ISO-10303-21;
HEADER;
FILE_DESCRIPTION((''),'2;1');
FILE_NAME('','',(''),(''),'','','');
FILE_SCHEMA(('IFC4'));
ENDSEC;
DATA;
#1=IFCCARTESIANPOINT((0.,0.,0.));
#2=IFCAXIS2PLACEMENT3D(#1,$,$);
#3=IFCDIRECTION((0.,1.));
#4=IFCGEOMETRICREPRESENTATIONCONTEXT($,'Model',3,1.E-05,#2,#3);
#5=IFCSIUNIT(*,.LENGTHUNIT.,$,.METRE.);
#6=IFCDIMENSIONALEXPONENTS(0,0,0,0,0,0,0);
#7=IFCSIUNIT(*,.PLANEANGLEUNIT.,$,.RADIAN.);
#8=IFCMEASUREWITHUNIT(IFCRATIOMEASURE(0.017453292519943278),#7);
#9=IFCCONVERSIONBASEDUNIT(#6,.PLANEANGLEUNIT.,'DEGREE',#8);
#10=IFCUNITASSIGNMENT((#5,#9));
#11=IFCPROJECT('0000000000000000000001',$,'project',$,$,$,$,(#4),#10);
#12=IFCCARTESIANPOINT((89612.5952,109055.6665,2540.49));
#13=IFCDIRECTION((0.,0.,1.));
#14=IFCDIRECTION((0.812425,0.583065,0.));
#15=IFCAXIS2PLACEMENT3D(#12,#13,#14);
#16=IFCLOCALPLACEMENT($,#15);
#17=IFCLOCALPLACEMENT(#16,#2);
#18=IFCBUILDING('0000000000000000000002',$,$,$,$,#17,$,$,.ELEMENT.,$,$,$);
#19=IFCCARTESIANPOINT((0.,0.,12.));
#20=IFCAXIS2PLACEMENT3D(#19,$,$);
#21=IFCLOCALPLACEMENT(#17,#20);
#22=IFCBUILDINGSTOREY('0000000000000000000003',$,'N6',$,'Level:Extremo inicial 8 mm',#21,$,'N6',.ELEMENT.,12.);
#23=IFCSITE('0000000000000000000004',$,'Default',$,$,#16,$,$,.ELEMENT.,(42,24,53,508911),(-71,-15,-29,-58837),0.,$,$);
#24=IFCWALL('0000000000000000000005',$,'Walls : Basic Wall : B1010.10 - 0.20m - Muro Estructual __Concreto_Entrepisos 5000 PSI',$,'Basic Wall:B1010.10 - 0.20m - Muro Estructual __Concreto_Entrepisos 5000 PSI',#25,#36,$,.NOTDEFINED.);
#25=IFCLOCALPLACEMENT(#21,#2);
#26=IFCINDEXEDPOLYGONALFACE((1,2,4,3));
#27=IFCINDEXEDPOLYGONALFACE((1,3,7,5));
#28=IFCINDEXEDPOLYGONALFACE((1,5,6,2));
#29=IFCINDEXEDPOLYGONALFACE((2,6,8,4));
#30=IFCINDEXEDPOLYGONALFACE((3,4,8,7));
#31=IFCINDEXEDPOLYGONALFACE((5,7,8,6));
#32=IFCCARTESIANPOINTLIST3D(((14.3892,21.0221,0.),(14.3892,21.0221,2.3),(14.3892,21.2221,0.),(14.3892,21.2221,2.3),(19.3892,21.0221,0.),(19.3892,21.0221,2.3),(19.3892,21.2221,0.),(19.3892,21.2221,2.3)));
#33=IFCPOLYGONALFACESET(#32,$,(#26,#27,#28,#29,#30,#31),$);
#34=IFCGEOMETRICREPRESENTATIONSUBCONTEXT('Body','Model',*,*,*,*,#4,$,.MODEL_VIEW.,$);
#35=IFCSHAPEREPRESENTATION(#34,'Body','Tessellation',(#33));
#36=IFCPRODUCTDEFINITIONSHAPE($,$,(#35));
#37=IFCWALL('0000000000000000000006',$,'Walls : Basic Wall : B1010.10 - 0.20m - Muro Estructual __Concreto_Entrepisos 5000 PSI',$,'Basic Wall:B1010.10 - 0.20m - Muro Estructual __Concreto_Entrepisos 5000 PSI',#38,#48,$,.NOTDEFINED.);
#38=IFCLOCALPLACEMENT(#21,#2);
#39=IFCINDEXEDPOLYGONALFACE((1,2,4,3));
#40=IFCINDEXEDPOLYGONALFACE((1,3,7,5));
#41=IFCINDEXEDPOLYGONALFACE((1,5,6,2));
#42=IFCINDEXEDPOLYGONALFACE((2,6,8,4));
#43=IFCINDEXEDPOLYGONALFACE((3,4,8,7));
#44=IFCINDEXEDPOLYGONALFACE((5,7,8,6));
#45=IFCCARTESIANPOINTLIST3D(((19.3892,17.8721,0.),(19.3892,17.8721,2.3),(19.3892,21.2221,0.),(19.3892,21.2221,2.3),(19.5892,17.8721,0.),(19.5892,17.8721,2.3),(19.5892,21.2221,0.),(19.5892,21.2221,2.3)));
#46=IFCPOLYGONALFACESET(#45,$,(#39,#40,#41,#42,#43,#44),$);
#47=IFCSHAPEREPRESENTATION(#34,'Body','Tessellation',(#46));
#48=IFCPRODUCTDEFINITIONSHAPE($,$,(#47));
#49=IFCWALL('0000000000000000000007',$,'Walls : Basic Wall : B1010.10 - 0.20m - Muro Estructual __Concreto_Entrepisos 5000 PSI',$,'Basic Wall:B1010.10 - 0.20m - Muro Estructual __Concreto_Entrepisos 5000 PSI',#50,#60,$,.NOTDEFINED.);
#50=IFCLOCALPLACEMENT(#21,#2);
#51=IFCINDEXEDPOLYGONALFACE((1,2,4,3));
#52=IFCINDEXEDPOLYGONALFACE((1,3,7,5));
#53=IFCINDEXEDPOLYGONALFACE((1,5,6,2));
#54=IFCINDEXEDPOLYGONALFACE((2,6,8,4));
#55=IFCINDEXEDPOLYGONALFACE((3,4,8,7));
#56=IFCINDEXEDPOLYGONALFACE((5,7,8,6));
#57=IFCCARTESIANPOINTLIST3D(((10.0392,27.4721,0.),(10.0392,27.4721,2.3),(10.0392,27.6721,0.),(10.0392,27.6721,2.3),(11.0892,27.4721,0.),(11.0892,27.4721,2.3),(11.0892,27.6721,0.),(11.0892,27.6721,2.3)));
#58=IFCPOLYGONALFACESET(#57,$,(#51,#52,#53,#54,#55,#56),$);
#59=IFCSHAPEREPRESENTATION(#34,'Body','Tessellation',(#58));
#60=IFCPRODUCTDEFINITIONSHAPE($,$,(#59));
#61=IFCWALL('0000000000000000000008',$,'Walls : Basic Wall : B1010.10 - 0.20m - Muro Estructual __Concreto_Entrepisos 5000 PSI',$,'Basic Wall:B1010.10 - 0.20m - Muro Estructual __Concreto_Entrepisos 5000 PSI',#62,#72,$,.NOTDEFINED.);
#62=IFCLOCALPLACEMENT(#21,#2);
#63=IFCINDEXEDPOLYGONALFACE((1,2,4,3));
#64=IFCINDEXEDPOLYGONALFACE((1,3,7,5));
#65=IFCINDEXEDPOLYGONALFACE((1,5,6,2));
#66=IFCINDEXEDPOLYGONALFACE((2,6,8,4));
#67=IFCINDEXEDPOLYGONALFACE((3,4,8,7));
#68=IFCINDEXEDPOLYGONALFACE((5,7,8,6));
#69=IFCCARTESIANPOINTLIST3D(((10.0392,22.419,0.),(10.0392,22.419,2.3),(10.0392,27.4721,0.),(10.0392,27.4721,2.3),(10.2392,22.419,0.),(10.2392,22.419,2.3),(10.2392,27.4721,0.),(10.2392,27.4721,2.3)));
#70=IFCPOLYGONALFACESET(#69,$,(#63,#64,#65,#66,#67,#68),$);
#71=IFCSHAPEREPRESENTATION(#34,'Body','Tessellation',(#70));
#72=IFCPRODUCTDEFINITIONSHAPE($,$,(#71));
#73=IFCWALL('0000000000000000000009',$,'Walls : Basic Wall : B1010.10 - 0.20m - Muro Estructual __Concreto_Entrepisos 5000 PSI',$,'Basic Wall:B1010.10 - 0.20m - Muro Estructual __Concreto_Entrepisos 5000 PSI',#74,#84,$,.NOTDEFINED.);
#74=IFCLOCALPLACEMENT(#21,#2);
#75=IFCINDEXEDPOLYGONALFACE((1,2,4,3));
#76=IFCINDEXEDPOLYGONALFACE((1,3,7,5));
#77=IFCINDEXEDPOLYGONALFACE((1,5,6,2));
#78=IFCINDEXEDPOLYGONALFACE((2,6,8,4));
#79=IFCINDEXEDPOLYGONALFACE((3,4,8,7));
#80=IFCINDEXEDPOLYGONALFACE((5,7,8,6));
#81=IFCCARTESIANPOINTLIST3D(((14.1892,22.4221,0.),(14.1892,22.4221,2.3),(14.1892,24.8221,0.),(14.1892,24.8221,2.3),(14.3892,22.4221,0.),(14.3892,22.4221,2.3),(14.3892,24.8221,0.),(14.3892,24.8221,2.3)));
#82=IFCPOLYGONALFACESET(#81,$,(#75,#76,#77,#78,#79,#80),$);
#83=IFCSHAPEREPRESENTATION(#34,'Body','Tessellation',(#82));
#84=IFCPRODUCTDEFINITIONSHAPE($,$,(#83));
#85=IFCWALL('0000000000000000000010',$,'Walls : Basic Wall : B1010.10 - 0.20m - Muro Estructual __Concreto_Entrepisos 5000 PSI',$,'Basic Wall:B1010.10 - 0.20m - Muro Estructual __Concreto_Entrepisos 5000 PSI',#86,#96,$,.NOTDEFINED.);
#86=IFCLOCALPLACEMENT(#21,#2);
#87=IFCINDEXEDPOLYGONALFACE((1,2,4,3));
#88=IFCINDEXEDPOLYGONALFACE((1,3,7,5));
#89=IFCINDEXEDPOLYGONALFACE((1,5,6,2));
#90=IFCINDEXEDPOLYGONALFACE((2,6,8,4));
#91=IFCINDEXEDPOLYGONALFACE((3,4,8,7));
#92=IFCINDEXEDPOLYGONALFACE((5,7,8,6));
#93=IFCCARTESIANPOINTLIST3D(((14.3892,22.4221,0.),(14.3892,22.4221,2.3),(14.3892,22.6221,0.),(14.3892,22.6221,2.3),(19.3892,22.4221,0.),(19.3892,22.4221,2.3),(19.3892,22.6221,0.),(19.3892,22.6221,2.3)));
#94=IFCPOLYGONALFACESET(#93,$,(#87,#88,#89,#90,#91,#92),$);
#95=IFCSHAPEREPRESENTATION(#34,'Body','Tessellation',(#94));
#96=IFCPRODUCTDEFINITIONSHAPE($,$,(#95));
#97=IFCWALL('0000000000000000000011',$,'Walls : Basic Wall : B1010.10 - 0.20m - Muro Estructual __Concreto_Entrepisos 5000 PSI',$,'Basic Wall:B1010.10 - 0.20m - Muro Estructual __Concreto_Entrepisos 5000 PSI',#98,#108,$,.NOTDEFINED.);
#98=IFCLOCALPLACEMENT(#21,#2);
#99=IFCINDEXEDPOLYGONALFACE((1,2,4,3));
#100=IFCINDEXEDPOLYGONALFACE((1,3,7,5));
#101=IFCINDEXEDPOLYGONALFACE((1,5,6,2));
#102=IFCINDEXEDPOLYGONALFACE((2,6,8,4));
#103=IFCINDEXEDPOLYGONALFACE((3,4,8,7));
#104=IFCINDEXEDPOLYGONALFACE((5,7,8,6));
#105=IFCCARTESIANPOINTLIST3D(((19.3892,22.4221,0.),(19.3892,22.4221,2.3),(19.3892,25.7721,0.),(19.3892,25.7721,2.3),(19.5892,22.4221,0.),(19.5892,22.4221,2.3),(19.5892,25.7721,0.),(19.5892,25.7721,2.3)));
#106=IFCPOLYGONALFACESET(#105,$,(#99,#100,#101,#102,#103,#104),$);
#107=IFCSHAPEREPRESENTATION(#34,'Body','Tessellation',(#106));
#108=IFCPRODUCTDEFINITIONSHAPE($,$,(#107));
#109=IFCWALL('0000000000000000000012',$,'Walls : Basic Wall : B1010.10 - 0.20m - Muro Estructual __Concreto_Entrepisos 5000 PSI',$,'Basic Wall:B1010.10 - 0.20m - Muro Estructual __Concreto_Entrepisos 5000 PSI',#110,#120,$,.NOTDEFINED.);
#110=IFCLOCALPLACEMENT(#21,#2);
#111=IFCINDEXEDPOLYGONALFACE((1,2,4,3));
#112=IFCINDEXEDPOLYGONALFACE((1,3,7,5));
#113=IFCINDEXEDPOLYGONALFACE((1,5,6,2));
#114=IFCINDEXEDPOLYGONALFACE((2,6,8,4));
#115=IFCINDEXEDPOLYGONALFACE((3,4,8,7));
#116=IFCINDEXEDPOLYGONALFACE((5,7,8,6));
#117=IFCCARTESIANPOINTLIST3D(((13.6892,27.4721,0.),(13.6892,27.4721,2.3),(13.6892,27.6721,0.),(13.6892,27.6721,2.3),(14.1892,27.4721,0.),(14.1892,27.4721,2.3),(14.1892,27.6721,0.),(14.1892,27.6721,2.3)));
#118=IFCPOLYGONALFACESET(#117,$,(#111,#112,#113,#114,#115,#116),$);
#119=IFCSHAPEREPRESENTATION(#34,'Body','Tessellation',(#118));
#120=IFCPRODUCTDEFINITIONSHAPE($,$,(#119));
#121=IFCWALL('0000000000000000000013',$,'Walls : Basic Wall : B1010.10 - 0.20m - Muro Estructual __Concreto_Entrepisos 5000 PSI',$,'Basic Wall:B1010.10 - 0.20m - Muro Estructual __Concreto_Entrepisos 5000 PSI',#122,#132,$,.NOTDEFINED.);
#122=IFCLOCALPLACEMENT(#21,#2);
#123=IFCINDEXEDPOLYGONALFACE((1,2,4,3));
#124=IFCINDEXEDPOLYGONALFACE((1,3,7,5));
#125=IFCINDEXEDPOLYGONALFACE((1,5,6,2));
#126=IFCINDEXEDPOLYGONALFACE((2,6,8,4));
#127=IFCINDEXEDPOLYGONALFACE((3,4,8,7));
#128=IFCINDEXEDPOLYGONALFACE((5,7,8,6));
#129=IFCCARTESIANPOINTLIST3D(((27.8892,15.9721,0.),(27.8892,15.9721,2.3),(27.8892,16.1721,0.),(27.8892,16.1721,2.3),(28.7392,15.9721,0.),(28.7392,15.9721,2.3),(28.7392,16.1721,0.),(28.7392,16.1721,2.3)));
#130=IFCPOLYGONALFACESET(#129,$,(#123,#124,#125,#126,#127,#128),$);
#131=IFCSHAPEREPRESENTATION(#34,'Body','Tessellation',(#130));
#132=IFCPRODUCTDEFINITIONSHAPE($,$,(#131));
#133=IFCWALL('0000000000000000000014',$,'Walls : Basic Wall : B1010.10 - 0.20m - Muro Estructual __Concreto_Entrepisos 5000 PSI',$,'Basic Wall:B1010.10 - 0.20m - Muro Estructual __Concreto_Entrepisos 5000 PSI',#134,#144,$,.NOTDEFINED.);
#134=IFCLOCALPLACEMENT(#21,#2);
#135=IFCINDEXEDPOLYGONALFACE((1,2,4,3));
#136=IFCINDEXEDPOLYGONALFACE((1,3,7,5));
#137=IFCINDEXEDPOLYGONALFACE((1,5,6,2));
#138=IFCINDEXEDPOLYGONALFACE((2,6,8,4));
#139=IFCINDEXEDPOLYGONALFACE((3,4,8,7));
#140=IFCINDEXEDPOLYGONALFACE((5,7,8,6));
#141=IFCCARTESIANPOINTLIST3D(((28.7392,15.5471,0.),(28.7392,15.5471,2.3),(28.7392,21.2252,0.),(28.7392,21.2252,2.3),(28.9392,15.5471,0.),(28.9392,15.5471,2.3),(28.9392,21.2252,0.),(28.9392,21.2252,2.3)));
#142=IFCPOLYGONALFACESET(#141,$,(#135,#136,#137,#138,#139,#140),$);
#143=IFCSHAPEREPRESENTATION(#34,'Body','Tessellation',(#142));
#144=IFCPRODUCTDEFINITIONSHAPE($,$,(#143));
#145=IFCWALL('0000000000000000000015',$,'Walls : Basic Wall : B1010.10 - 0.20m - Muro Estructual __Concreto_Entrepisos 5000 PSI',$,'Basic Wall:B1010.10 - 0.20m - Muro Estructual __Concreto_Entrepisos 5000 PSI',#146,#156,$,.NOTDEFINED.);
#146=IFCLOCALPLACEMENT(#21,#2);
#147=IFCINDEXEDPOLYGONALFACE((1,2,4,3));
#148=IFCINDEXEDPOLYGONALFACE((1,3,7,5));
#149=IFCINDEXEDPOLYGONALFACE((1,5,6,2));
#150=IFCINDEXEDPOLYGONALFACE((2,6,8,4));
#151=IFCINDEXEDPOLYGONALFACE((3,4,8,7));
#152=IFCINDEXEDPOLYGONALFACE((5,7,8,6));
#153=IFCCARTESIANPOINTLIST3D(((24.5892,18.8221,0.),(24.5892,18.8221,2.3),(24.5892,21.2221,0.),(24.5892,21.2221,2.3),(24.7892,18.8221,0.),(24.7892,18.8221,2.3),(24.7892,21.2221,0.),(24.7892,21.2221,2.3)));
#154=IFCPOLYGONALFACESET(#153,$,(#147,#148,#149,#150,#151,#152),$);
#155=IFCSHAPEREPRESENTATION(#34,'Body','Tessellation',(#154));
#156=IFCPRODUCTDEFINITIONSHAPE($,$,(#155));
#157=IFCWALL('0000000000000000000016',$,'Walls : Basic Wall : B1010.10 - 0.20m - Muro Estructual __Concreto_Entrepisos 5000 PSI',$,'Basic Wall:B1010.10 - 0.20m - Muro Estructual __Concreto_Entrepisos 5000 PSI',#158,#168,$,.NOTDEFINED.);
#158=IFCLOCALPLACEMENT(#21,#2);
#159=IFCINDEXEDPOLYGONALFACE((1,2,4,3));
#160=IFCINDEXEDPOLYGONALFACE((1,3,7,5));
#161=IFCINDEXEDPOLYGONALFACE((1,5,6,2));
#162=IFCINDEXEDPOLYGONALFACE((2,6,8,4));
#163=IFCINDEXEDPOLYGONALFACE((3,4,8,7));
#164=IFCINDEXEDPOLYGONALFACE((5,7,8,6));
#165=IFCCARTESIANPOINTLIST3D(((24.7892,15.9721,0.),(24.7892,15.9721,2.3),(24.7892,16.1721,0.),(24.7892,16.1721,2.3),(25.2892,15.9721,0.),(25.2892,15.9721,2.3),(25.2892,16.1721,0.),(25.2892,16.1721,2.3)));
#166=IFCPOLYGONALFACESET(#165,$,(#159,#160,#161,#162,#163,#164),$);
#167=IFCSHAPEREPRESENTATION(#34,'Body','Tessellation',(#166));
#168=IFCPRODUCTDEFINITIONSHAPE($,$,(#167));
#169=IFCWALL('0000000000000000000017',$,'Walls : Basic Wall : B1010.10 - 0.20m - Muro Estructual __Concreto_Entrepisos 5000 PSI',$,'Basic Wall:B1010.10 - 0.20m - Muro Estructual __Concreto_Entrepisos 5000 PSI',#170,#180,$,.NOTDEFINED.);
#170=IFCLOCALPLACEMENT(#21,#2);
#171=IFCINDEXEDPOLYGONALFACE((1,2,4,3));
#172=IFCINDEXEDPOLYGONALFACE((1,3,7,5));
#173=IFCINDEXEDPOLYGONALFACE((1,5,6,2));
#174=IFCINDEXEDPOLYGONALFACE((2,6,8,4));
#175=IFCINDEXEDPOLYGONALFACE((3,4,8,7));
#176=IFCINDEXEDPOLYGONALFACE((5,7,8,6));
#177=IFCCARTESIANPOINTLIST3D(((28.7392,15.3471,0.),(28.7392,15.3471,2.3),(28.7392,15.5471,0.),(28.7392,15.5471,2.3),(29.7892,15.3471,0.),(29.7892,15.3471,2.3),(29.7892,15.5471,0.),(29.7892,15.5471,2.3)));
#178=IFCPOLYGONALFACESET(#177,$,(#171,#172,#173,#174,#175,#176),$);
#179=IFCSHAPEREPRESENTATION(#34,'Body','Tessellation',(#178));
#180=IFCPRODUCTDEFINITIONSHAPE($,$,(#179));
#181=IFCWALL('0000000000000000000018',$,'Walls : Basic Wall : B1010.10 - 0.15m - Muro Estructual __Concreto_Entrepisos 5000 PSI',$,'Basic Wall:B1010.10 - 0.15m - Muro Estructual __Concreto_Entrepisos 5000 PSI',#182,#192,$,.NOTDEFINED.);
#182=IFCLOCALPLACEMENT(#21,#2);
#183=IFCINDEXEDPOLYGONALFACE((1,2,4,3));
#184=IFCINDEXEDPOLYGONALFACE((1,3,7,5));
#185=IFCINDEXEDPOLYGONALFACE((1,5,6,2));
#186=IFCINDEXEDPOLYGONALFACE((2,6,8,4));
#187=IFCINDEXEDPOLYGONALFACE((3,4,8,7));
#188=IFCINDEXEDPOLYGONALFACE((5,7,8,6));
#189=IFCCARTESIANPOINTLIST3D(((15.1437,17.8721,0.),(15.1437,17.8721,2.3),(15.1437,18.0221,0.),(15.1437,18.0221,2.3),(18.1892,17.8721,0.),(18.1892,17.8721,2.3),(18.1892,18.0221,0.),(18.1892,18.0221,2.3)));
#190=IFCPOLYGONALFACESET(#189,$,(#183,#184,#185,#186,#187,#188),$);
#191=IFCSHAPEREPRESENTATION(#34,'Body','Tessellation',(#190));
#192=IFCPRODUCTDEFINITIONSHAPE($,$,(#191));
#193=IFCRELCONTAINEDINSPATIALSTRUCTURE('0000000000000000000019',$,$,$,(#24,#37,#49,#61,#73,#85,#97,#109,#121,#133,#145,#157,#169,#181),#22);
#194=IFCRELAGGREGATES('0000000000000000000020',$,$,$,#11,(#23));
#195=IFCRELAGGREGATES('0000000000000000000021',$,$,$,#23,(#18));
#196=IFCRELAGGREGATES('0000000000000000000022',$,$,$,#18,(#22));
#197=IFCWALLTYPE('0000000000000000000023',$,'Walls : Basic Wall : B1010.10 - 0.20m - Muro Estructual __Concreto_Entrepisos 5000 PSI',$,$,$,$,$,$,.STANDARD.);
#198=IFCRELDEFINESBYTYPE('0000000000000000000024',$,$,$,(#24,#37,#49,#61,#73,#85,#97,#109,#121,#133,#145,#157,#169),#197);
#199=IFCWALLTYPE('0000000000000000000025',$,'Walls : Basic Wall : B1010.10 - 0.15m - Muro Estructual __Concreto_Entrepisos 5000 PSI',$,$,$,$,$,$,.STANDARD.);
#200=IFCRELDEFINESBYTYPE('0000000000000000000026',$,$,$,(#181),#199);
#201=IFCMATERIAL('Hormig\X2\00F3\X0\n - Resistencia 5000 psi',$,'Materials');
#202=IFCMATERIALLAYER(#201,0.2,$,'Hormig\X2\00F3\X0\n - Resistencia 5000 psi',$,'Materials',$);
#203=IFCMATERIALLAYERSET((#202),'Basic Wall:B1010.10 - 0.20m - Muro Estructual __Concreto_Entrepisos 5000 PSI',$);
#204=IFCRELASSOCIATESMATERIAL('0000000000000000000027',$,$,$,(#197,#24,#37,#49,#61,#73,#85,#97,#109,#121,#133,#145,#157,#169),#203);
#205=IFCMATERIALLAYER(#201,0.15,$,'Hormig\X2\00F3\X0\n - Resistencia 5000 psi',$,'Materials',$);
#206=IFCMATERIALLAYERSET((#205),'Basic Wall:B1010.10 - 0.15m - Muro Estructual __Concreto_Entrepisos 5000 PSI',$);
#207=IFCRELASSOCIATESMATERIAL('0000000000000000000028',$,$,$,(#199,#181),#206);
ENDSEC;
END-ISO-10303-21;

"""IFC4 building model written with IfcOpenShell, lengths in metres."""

from ifc_helpers import new_model, entity, si_unit, converted_unit, direction, frame, frame_2d, origin, place, context, subcontext, project, spatial, rectangle, extrude, material, layer, layer_set, layer_usage, type_object, element, save


model = new_model("IFC4")

# Units and contexts
model_context = context("Model", 3, precision=1e-05, world=origin(), true_north=direction((0.0, 1.0)))
body_context = subcontext(model_context, "Body", "Model", "MODEL_VIEW")
ifc_project = project(units=[si_unit("LENGTHUNIT", "METRE"), converted_unit("PLANEANGLEUNIT", "DEGREE", entity("IfcRatioMeasure", 0.017453292519943278), si_unit("PLANEANGLEUNIT", "RADIAN"), dimensions=[0, 0, 0, 0, 0, 0, 0])], contexts=[model_context])

# Site, building, storey
site_placement = place(None, frame((89612.5952, 109055.6665, 2540.49), z_axis=(0.0, 0.0, 1.0), x_axis=(0.812425, 0.583065, 0.0)))
site = spatial("IfcSite", under=ifc_project, at=site_placement, Name="Default", CompositionType="ELEMENT", RefLatitude=(42, 24, 53, 508911), RefLongitude=(-71, -15, -29, -58837), RefElevation=0.0)
building_placement = place(site_placement, origin())
building = spatial("IfcBuilding", under=site, at=building_placement, CompositionType="ELEMENT")
storey_placement = place(building_placement, frame((0.0, 0.0, 12.0)))
storey = spatial("IfcBuildingStorey", under=building, at=storey_placement, Name="N6", ObjectType="Level:Extremo inicial 8 mm", LongName="N6", CompositionType="ELEMENT", Elevation=12.0)

# Walls
ifc_material = material(Name="Hormigón - Resistencia 5000 psi", Category="Materials")
ifc_layer_1 = layer(ifc_material, 0.2, Name="Hormigón - Resistencia 5000 psi", Category="Materials")
ifc_layer_set_1 = layer_set([ifc_layer_1], Name="Basic Wall:B1010.10 - 0.20m - Muro Estructual __Concreto_Entrepisos 5000 PSI")
ifc_layer_usage_1 = layer_usage(ifc_layer_set_1, "AXIS2", "NEGATIVE", 0.1)
wall_type_1 = type_object("IfcWallType", Name="Walls : Basic Wall : B1010.10 - 0.20m - Muro Estructual __Concreto_Entrepisos 5000 PSI", PredefinedType="STANDARD", material=ifc_layer_set_1)
wall_1_placement = place(storey_placement, frame((14.3892, 21.1221, 0.0)))
element("IfcWall", 1, at=wall_1_placement, inside=storey, type_object=wall_type_1, material=ifc_layer_usage_1, Name="Walls : Basic Wall : B1010.10 - 0.20m - Muro Estructual __Concreto_Entrepisos 5000 PSI", ObjectType="Basic Wall:B1010.10 - 0.20m - Muro Estructual __Concreto_Entrepisos 5000 PSI", PredefinedType="NOTDEFINED", context=body_context, shape_type="SweptSolid", body=[
    extrude(rectangle(XDim=5.0, YDim=0.2, at=frame_2d((2.5, 0.0), x_axis=(-1.0, 0.0))), origin(), (0.0, 0.0, 1.0), 2.3),
])
ifc_layer_usage_2 = layer_usage(ifc_layer_set_1, "AXIS2", "NEGATIVE", 0.1)
wall_2_placement = place(storey_placement, frame((19.4892, 21.2221, 0.0), z_axis=(0.0, 0.0, 1.0), x_axis=(0.0, -1.0, 0.0)))
element("IfcWall", 2, at=wall_2_placement, inside=storey, type_object=wall_type_1, material=ifc_layer_usage_2, Name="Walls : Basic Wall : B1010.10 - 0.20m - Muro Estructual __Concreto_Entrepisos 5000 PSI", ObjectType="Basic Wall:B1010.10 - 0.20m - Muro Estructual __Concreto_Entrepisos 5000 PSI", PredefinedType="NOTDEFINED", context=body_context, shape_type="SweptSolid", body=[
    extrude(rectangle(XDim=3.35, YDim=0.2, at=frame_2d((1.675, 0.0), x_axis=(-1.0, 0.0))), origin(), (0.0, 0.0, 1.0), 2.3),
])
ifc_layer_usage_3 = layer_usage(ifc_layer_set_1, "AXIS2", "POSITIVE", -0.1)
wall_3_placement = place(storey_placement, frame((11.0892, 27.5721, 0.0), z_axis=(0.0, 0.0, 1.0), x_axis=(-1.0, 0.0, 0.0)))
element("IfcWall", 3, at=wall_3_placement, inside=storey, type_object=wall_type_1, material=ifc_layer_usage_3, Name="Walls : Basic Wall : B1010.10 - 0.20m - Muro Estructual __Concreto_Entrepisos 5000 PSI", ObjectType="Basic Wall:B1010.10 - 0.20m - Muro Estructual __Concreto_Entrepisos 5000 PSI", PredefinedType="NOTDEFINED", context=body_context, shape_type="SweptSolid", body=[
    extrude(rectangle(XDim=1.05, YDim=0.2, at=frame_2d((0.525, 0.0), x_axis=(-1.0, 0.0))), origin(), (0.0, 0.0, 1.0), 2.3),
])
ifc_layer_usage_4 = layer_usage(ifc_layer_set_1, "AXIS2", "POSITIVE", -0.1)
wall_4_placement = place(storey_placement, frame((10.1392, 27.4721, 0.0), z_axis=(0.0, 0.0, 1.0), x_axis=(0.0, -1.0, 0.0)))
element("IfcWall", 4, at=wall_4_placement, inside=storey, type_object=wall_type_1, material=ifc_layer_usage_4, Name="Walls : Basic Wall : B1010.10 - 0.20m - Muro Estructual __Concreto_Entrepisos 5000 PSI", ObjectType="Basic Wall:B1010.10 - 0.20m - Muro Estructual __Concreto_Entrepisos 5000 PSI", PredefinedType="NOTDEFINED", context=body_context, shape_type="SweptSolid", body=[
    extrude(rectangle(XDim=5.0531, YDim=0.2, at=frame_2d((2.5265, 0.0), x_axis=(-1.0, 0.0))), origin(), (0.0, 0.0, 1.0), 2.3),
])
ifc_layer_usage_5 = layer_usage(ifc_layer_set_1, "AXIS2", "POSITIVE", -0.1)
wall_5_placement = place(storey_placement, frame((14.2892, 24.8221, 0.0), z_axis=(0.0, 0.0, 1.0), x_axis=(0.0, -1.0, 0.0)))
element("IfcWall", 5, at=wall_5_placement, inside=storey, type_object=wall_type_1, material=ifc_layer_usage_5, Name="Walls : Basic Wall : B1010.10 - 0.20m - Muro Estructual __Concreto_Entrepisos 5000 PSI", ObjectType="Basic Wall:B1010.10 - 0.20m - Muro Estructual __Concreto_Entrepisos 5000 PSI", PredefinedType="NOTDEFINED", context=body_context, shape_type="SweptSolid", body=[
    extrude(rectangle(XDim=2.4, YDim=0.2, at=frame_2d((1.2, 0.0), x_axis=(-1.0, 0.0))), origin(), (0.0, 0.0, 1.0), 2.3),
])
ifc_layer_usage_6 = layer_usage(ifc_layer_set_1, "AXIS2", "POSITIVE", -0.1)
wall_6_placement = place(storey_placement, frame((14.3892, 22.5221, 0.0)))
element("IfcWall", 6, at=wall_6_placement, inside=storey, type_object=wall_type_1, material=ifc_layer_usage_6, Name="Walls : Basic Wall : B1010.10 - 0.20m - Muro Estructual __Concreto_Entrepisos 5000 PSI", ObjectType="Basic Wall:B1010.10 - 0.20m - Muro Estructual __Concreto_Entrepisos 5000 PSI", PredefinedType="NOTDEFINED", context=body_context, shape_type="SweptSolid", body=[
    extrude(rectangle(XDim=5.0, YDim=0.2, at=frame_2d((2.5, 0.0), x_axis=(-1.0, 0.0))), origin(), (0.0, 0.0, 1.0), 2.3),
])
ifc_layer_usage_7 = layer_usage(ifc_layer_set_1, "AXIS2", "POSITIVE", -0.1)
wall_7_placement = place(storey_placement, frame((19.4892, 22.4221, 0.0), z_axis=(0.0, 0.0, 1.0), x_axis=(0.0, 1.0, 0.0)))
element("IfcWall", 7, at=wall_7_placement, inside=storey, type_object=wall_type_1, material=ifc_layer_usage_7, Name="Walls : Basic Wall : B1010.10 - 0.20m - Muro Estructual __Concreto_Entrepisos 5000 PSI", ObjectType="Basic Wall:B1010.10 - 0.20m - Muro Estructual __Concreto_Entrepisos 5000 PSI", PredefinedType="NOTDEFINED", context=body_context, shape_type="SweptSolid", body=[
    extrude(rectangle(XDim=3.35, YDim=0.2, at=frame_2d((1.675, 0.0), x_axis=(-1.0, 0.0))), origin(), (0.0, 0.0, 1.0), 2.3),
])
ifc_layer_usage_8 = layer_usage(ifc_layer_set_1, "AXIS2", "POSITIVE", -0.1)
wall_8_placement = place(storey_placement, frame((13.6892, 27.5721, 0.0)))
element("IfcWall", 8, at=wall_8_placement, inside=storey, type_object=wall_type_1, material=ifc_layer_usage_8, Name="Walls : Basic Wall : B1010.10 - 0.20m - Muro Estructual __Concreto_Entrepisos 5000 PSI", ObjectType="Basic Wall:B1010.10 - 0.20m - Muro Estructual __Concreto_Entrepisos 5000 PSI", PredefinedType="NOTDEFINED", context=body_context, shape_type="SweptSolid", body=[
    extrude(rectangle(XDim=0.5, YDim=0.2, at=frame_2d((0.25, 0.0), x_axis=(-1.0, 0.0))), origin(), (0.0, 0.0, 1.0), 2.3),
])
ifc_layer_usage_9 = layer_usage(ifc_layer_set_1, "AXIS2", "POSITIVE", -0.1)
wall_9_placement = place(storey_placement, frame((27.8892, 16.0721, 0.0)))
element("IfcWall", 9, at=wall_9_placement, inside=storey, type_object=wall_type_1, material=ifc_layer_usage_9, Name="Walls : Basic Wall : B1010.10 - 0.20m - Muro Estructual __Concreto_Entrepisos 5000 PSI", ObjectType="Basic Wall:B1010.10 - 0.20m - Muro Estructual __Concreto_Entrepisos 5000 PSI", PredefinedType="NOTDEFINED", context=body_context, shape_type="SweptSolid", body=[
    extrude(rectangle(XDim=0.85, YDim=0.2, at=frame_2d((0.425, 0.0), x_axis=(-1.0, 0.0))), origin(), (0.0, 0.0, 1.0), 2.3),
])
ifc_layer_usage_10 = layer_usage(ifc_layer_set_1, "AXIS2", "POSITIVE", -0.1)
wall_10_placement = place(storey_placement, frame((28.8392, 15.5471, 0.0), z_axis=(0.0, 0.0, 1.0), x_axis=(0.0, 1.0, 0.0)))
element("IfcWall", 10, at=wall_10_placement, inside=storey, type_object=wall_type_1, material=ifc_layer_usage_10, Name="Walls : Basic Wall : B1010.10 - 0.20m - Muro Estructual __Concreto_Entrepisos 5000 PSI", ObjectType="Basic Wall:B1010.10 - 0.20m - Muro Estructual __Concreto_Entrepisos 5000 PSI", PredefinedType="NOTDEFINED", context=body_context, shape_type="SweptSolid", body=[
    extrude(rectangle(XDim=5.6781, YDim=0.2, at=frame_2d((2.839, 0.0), x_axis=(-1.0, 0.0))), origin(), (0.0, 0.0, 1.0), 2.3),
])
ifc_layer_usage_11 = layer_usage(ifc_layer_set_1, "AXIS2", "POSITIVE", -0.1)
wall_11_placement = place(storey_placement, frame((24.6892, 18.8221, 0.0), z_axis=(0.0, 0.0, 1.0), x_axis=(0.0, 1.0, 0.0)))
element("IfcWall", 11, at=wall_11_placement, inside=storey, type_object=wall_type_1, material=ifc_layer_usage_11, Name="Walls : Basic Wall : B1010.10 - 0.20m - Muro Estructual __Concreto_Entrepisos 5000 PSI", ObjectType="Basic Wall:B1010.10 - 0.20m - Muro Estructual __Concreto_Entrepisos 5000 PSI", PredefinedType="NOTDEFINED", context=body_context, shape_type="SweptSolid", body=[
    extrude(rectangle(XDim=2.4, YDim=0.2, at=frame_2d((1.2, 0.0), x_axis=(-1.0, 0.0))), origin(), (0.0, 0.0, 1.0), 2.3),
])
ifc_layer_usage_12 = layer_usage(ifc_layer_set_1, "AXIS2", "POSITIVE", -0.1)
wall_12_placement = place(storey_placement, frame((25.2892, 16.0721, 0.0), z_axis=(0.0, 0.0, 1.0), x_axis=(-1.0, 0.0, 0.0)))
element("IfcWall", 12, at=wall_12_placement, inside=storey, type_object=wall_type_1, material=ifc_layer_usage_12, Name="Walls : Basic Wall : B1010.10 - 0.20m - Muro Estructual __Concreto_Entrepisos 5000 PSI", ObjectType="Basic Wall:B1010.10 - 0.20m - Muro Estructual __Concreto_Entrepisos 5000 PSI", PredefinedType="NOTDEFINED", context=body_context, shape_type="SweptSolid", body=[
    extrude(rectangle(XDim=0.5, YDim=0.2, at=frame_2d((0.25, 0.0), x_axis=(-1.0, 0.0))), origin(), (0.0, 0.0, 1.0), 2.3),
])
ifc_layer_usage_13 = layer_usage(ifc_layer_set_1, "AXIS2", "NEGATIVE", 0.1)
wall_13_placement = place(storey_placement, frame((29.7892, 15.4471, 0.0), z_axis=(0.0, 0.0, 1.0), x_axis=(-1.0, 0.0, 0.0)))
element("IfcWall", 13, at=wall_13_placement, inside=storey, type_object=wall_type_1, material=ifc_layer_usage_13, Name="Walls : Basic Wall : B1010.10 - 0.20m - Muro Estructual __Concreto_Entrepisos 5000 PSI", ObjectType="Basic Wall:B1010.10 - 0.20m - Muro Estructual __Concreto_Entrepisos 5000 PSI", PredefinedType="NOTDEFINED", context=body_context, shape_type="SweptSolid", body=[
    extrude(rectangle(XDim=1.05, YDim=0.2, at=frame_2d((0.525, 0.0), x_axis=(-1.0, 0.0))), origin(), (0.0, 0.0, 1.0), 2.3),
])
ifc_layer_2 = layer(ifc_material, 0.15, Name="Hormigón - Resistencia 5000 psi", Category="Materials")
ifc_layer_set_2 = layer_set([ifc_layer_2], Name="Basic Wall:B1010.10 - 0.15m - Muro Estructual __Concreto_Entrepisos 5000 PSI")
ifc_layer_usage_14 = layer_usage(ifc_layer_set_2, "AXIS2", "NEGATIVE", 0.075)
wall_type_2 = type_object("IfcWallType", Name="Walls : Basic Wall : B1010.10 - 0.15m - Muro Estructual __Concreto_Entrepisos 5000 PSI", PredefinedType="STANDARD", material=ifc_layer_set_2)
wall_14_placement = place(storey_placement, frame((18.1892, 17.9471, 0.0), z_axis=(0.0, 0.0, 1.0), x_axis=(-1.0, 0.0, 0.0)))
element("IfcWall", 14, at=wall_14_placement, inside=storey, type_object=wall_type_2, material=ifc_layer_usage_14, Name="Walls : Basic Wall : B1010.10 - 0.15m - Muro Estructual __Concreto_Entrepisos 5000 PSI", ObjectType="Basic Wall:B1010.10 - 0.15m - Muro Estructual __Concreto_Entrepisos 5000 PSI", PredefinedType="NOTDEFINED", context=body_context, shape_type="SweptSolid", body=[
    extrude(rectangle(XDim=3.0455, YDim=0.15, at=frame_2d((1.5228, 0.0), x_axis=(-1.0, 0.0))), origin(), (0.0, 0.0, 1.0), 2.3),
])

save(model, "model.ifc")
